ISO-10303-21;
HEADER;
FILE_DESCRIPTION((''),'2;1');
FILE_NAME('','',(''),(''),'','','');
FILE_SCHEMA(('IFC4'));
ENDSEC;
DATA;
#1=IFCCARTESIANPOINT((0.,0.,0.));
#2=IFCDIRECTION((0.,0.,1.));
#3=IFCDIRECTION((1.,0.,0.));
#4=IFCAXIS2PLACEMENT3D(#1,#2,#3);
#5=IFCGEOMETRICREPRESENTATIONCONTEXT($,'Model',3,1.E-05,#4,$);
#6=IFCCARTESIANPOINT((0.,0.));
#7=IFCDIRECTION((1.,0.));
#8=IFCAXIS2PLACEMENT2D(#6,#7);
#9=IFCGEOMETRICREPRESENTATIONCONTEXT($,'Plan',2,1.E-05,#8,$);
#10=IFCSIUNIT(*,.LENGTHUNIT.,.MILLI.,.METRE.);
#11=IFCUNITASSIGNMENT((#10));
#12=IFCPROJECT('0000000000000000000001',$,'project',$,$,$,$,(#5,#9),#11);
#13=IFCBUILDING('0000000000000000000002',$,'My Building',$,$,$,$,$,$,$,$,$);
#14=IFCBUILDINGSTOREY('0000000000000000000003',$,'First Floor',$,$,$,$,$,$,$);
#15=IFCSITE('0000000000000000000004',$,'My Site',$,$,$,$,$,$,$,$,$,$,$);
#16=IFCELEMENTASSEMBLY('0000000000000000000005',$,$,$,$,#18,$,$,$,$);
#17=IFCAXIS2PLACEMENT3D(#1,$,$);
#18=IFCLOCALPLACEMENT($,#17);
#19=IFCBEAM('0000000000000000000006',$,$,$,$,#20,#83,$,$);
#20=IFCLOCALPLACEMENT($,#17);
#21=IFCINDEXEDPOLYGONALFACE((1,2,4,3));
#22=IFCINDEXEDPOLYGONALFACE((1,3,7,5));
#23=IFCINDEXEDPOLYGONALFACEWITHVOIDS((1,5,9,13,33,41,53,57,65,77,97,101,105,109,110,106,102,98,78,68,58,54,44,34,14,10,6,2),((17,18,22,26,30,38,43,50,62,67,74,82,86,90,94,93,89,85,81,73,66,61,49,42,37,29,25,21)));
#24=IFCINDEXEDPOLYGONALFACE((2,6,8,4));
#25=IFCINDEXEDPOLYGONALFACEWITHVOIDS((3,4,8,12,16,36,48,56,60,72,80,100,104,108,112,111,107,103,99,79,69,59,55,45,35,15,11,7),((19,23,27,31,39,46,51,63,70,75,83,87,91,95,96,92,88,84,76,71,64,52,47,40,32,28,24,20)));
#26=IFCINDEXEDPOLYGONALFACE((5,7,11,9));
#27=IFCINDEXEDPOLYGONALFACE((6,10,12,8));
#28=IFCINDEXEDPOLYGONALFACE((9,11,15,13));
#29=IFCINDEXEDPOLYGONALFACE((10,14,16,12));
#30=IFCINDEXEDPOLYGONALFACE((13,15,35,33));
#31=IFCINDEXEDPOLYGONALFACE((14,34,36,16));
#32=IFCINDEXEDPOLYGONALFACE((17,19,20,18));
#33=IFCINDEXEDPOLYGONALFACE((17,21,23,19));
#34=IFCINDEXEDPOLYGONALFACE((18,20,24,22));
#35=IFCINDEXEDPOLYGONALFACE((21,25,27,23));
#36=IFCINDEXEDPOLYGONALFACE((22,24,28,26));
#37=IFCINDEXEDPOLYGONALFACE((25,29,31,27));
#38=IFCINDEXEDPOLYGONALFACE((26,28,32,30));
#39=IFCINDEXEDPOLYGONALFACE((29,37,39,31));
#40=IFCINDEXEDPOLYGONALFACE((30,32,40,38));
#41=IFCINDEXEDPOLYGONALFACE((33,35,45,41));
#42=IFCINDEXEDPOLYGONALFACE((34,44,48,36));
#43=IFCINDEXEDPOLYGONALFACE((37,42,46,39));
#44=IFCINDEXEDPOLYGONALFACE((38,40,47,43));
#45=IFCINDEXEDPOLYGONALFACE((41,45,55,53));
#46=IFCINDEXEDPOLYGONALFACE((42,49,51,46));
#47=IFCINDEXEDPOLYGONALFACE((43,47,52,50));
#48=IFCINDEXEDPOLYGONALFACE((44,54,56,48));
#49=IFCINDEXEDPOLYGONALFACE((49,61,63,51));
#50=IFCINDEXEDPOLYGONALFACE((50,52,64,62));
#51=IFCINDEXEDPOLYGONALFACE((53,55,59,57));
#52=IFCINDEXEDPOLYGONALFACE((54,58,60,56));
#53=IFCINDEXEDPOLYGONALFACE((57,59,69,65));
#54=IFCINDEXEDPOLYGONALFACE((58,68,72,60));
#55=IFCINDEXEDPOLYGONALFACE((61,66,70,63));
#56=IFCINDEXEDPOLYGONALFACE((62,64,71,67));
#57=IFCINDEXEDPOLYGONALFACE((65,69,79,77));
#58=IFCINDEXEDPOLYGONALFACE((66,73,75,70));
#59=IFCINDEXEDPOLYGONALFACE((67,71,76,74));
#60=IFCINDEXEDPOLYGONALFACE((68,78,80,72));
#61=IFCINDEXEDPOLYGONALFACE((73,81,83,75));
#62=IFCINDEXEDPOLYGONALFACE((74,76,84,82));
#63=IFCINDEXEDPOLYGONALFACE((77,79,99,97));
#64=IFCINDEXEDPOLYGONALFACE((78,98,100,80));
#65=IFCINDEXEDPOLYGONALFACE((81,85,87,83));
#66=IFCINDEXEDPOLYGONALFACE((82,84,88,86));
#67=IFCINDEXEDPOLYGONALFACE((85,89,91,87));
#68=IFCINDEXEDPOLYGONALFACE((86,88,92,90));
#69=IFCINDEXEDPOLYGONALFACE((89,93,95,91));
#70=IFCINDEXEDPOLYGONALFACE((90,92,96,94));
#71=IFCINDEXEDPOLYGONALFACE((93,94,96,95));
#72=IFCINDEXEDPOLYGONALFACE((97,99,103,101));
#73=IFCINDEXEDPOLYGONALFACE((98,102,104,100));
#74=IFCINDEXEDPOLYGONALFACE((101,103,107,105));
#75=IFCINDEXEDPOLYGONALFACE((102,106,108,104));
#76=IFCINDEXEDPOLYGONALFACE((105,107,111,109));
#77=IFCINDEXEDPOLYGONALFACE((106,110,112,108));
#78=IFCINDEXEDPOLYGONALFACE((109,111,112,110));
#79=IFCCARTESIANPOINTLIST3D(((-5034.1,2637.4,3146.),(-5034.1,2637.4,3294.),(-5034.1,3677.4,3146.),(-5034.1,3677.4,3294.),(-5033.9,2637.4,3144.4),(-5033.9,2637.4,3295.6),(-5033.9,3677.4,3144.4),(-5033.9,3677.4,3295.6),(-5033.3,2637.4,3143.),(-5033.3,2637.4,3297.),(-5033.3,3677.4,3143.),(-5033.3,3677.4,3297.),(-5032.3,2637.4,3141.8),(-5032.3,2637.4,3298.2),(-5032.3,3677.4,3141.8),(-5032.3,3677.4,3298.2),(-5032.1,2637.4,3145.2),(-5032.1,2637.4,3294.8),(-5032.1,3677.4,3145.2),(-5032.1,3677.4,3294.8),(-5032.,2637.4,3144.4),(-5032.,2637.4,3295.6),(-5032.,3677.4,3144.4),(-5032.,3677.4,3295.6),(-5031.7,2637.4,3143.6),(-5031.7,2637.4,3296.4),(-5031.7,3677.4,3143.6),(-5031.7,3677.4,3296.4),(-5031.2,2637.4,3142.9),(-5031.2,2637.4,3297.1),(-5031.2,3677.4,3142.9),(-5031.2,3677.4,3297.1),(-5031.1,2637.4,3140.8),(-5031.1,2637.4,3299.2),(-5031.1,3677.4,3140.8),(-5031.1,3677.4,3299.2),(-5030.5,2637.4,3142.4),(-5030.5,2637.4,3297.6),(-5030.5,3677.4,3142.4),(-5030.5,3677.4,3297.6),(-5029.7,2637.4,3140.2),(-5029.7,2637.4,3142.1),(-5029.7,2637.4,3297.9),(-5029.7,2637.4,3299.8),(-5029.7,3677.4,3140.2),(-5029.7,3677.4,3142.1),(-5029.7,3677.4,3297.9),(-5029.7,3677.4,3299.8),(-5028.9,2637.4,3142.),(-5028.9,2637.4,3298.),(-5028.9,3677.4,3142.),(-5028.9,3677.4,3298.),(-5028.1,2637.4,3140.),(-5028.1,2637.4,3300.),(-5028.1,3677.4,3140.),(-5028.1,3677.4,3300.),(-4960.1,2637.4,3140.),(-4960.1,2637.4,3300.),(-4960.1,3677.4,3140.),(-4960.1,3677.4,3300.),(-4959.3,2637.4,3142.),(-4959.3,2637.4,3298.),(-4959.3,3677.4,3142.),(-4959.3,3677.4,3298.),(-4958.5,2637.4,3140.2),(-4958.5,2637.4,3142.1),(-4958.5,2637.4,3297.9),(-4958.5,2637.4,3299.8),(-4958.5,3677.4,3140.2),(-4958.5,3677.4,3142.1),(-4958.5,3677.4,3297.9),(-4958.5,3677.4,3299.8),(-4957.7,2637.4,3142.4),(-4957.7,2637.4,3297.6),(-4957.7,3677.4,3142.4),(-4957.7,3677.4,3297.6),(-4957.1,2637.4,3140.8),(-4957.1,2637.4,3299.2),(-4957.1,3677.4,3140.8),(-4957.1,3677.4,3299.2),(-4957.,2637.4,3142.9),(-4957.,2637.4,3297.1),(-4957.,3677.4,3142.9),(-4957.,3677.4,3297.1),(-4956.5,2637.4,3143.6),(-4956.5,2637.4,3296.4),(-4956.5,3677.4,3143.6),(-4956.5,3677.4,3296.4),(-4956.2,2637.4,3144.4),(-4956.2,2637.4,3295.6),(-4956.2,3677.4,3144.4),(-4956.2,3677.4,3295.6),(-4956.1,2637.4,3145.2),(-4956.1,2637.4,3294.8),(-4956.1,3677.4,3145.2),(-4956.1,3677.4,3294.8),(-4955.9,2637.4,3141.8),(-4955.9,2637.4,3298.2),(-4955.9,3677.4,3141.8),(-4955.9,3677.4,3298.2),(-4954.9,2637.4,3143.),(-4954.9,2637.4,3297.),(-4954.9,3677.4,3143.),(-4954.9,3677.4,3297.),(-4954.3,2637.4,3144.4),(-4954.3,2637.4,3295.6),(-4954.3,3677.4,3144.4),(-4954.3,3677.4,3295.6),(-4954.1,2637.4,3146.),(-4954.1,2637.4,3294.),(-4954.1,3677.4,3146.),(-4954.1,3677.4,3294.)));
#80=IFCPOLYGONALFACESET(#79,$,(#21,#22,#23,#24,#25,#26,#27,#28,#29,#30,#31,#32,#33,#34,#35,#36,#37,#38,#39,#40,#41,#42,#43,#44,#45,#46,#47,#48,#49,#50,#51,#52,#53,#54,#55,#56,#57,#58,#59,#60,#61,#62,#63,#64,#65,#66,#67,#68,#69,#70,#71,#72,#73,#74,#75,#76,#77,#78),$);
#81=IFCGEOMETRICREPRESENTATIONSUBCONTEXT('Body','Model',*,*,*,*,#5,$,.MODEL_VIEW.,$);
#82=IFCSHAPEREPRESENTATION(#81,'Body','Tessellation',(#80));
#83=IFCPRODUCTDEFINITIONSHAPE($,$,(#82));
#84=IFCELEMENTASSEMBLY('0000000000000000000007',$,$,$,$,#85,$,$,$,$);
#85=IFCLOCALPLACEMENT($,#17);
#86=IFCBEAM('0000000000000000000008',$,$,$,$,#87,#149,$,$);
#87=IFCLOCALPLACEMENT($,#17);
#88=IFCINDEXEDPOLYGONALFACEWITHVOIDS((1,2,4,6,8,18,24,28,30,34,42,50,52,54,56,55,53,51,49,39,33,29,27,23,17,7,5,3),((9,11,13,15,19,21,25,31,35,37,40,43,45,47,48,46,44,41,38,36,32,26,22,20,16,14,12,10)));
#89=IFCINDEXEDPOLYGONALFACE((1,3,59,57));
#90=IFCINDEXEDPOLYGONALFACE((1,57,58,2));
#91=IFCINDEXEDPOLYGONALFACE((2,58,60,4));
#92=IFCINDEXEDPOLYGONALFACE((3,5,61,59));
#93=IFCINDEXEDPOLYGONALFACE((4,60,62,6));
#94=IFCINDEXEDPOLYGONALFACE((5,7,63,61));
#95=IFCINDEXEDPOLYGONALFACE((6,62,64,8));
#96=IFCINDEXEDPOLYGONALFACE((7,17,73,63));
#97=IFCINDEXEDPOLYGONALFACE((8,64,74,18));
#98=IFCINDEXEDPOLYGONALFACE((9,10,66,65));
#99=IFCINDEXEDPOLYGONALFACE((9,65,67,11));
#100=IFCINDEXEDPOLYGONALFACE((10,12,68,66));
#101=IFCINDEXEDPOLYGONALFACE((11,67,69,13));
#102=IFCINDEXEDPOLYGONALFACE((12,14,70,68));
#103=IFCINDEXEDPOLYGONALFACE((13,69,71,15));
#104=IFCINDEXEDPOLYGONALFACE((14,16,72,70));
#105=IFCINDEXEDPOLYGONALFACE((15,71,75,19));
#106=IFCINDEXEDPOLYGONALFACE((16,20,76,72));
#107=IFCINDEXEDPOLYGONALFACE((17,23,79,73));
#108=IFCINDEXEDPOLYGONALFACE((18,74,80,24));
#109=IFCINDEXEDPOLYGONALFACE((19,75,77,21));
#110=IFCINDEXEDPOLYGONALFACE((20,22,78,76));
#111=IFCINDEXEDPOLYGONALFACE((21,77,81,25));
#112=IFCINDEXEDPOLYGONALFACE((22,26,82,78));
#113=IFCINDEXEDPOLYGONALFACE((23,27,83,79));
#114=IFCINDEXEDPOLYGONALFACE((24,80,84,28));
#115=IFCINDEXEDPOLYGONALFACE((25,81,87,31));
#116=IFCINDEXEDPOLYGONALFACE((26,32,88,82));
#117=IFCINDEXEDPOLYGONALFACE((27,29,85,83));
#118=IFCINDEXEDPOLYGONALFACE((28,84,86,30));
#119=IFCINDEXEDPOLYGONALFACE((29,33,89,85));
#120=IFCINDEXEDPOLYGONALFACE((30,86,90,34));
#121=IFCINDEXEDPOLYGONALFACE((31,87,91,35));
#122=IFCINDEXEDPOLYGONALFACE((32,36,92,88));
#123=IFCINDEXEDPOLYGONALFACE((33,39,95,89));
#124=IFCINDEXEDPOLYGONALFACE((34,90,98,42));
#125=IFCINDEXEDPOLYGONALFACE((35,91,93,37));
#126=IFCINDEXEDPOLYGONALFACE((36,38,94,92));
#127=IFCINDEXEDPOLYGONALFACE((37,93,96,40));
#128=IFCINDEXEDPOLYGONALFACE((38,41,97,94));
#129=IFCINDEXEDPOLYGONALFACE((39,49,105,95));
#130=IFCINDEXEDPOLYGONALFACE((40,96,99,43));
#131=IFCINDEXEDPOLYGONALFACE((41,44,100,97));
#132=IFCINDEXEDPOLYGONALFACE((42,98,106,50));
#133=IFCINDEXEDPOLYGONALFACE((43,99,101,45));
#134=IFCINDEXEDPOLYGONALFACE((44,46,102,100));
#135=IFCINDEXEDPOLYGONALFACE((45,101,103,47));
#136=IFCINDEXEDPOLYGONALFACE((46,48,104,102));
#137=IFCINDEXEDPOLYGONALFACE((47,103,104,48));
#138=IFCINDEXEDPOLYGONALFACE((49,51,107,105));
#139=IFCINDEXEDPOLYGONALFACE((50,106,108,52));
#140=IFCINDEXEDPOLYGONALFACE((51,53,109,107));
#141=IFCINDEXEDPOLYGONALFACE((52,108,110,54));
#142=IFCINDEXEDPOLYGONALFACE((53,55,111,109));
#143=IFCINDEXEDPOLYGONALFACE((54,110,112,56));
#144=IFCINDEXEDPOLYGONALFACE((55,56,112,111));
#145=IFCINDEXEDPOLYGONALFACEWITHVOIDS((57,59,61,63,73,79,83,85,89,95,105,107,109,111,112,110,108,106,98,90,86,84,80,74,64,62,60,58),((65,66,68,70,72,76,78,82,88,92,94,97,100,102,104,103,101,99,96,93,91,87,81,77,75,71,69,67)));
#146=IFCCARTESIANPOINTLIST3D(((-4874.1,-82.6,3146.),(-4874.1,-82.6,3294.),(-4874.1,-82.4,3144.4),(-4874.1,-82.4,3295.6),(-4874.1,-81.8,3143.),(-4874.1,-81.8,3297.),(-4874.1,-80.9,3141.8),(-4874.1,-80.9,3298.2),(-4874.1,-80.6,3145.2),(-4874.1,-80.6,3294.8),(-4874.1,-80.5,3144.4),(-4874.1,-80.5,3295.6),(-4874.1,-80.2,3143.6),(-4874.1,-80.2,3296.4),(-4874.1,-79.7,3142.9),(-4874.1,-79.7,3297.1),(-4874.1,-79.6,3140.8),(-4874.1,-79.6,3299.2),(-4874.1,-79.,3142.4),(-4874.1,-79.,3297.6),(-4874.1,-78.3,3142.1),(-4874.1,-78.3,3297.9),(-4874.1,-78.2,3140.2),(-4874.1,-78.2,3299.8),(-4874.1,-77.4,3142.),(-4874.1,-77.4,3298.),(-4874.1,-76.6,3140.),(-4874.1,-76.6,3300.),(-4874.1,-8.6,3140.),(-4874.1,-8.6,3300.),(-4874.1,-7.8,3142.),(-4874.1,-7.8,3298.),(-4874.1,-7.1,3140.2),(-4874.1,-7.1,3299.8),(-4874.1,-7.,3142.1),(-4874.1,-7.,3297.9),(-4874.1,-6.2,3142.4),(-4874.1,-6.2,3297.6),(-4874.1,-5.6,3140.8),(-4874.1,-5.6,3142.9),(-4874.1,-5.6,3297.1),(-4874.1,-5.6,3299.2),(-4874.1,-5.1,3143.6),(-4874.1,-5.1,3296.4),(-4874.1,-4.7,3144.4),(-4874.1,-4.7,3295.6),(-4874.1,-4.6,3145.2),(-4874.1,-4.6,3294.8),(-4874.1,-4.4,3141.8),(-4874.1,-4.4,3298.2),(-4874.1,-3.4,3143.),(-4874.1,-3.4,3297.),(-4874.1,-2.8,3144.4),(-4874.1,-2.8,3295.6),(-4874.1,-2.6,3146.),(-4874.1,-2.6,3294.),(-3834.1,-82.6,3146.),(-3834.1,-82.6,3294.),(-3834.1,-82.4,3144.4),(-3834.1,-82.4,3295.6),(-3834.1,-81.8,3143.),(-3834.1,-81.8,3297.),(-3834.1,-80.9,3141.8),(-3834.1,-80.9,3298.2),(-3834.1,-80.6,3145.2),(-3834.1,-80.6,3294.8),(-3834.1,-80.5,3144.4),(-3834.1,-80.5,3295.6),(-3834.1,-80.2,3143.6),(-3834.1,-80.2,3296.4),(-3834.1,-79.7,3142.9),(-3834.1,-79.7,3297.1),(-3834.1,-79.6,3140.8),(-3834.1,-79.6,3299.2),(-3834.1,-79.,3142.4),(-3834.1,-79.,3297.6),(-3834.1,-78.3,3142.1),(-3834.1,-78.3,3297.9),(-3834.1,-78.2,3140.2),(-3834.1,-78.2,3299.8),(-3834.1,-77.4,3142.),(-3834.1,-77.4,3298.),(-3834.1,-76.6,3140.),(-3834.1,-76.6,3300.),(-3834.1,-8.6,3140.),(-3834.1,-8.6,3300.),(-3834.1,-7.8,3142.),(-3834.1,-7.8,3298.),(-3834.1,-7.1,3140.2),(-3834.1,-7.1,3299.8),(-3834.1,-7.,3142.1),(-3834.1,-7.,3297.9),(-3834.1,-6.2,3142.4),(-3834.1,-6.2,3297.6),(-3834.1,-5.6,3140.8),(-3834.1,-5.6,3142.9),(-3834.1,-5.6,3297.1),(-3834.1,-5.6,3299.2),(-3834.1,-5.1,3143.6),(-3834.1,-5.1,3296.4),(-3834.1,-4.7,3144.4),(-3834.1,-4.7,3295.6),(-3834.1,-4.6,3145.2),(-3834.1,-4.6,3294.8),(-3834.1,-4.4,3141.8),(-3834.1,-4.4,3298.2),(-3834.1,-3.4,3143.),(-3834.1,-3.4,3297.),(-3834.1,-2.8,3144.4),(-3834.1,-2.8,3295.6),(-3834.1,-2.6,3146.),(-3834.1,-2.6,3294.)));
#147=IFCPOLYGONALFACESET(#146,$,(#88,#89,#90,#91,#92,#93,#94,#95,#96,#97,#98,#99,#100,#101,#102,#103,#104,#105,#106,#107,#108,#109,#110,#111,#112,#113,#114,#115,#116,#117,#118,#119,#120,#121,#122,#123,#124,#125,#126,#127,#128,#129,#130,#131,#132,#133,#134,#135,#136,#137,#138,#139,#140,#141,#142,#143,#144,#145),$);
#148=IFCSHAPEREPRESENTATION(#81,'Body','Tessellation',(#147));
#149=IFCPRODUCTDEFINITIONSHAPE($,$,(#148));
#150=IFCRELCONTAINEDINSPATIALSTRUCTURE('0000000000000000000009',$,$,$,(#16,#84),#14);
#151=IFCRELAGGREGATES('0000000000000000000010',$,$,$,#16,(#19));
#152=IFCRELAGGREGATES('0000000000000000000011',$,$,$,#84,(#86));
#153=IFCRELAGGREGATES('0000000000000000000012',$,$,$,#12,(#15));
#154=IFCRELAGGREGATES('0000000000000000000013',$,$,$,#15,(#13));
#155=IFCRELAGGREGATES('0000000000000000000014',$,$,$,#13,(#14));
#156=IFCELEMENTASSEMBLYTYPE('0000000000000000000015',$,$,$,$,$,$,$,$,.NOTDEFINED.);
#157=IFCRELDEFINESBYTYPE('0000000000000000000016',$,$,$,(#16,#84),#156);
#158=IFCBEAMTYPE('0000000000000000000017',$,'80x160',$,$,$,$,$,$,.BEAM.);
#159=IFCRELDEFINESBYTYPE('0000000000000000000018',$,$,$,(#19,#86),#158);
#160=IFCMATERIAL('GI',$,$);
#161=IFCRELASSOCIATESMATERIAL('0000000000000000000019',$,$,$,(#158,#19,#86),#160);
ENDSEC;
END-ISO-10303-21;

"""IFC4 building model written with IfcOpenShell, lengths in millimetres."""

from ifc_helpers import new_model, si_unit, frame, origin_with_axes, origin_2d_with_axis, place, context, subcontext, project, spatial, hollow_rectangle, extrude, material, material_profile, profile_set, profile_usage, type_object, element, aggregate, save


model = new_model("IFC4")

# Units and contexts
model_context = context("Model", 3, precision=1e-05, world=origin_with_axes())
plan_context = context("Plan", 2, precision=1e-05, world=origin_2d_with_axis())
body_context = subcontext(model_context, "Body", "Model", "MODEL_VIEW")
ifc_project = project(units=[si_unit("LENGTHUNIT", "METRE", prefix="MILLI")], contexts=[model_context, plan_context])

# Site, building, storey
site = spatial("IfcSite", under=ifc_project, Name="My Site")
building = spatial("IfcBuilding", under=site, Name="My Building")
storey = spatial("IfcBuildingStorey", under=building, Name="First Floor")

# Element assemblies, beams
element_assembly_type = type_object("IfcElementAssemblyType", PredefinedType="NOTDEFINED")
ifc_material = material(Name="GI")
ifc_material_profile = material_profile(ifc_material, hollow_rectangle(XDim=80.0, YDim=160.0, WallThickness=2.0, InnerFilletRadius=3.2, OuterFilletRadius=6.0))
ifc_profile_set = profile_set([ifc_material_profile], Name="80x160 GI Rectangular Hollow")
beam_type = type_object("IfcBeamType", Name="80x160", PredefinedType="BEAM", material=ifc_profile_set)
assembly_1_placement = place(None, frame((-4994.1, 2557.4, 3220.0), z_axis=(0.0, 1.0, 0.0), x_axis=(1.0, 0.0, 0.0)))
assembly_1 = element("IfcElementAssembly", 1, at=assembly_1_placement, inside=storey, type_object=element_assembly_type)
ifc_profile_usage_1 = profile_usage(ifc_profile_set)
beam_1_placement = place(assembly_1_placement, frame((0.0, 0.0, 80.0), z_axis=(0.0, 0.0, 1.0), x_axis=(1.0, 0.0, 0.0)))
beam_1 = element("IfcBeam", 2, at=beam_1_placement, type_object=beam_type, material=ifc_profile_usage_1, context=body_context, shape_type="SweptSolid", body=[
    extrude(hollow_rectangle(XDim=80.0, YDim=160.0, WallThickness=2.0, InnerFilletRadius=3.2, OuterFilletRadius=6.0), origin_with_axes(), (0.0, 0.0, 1.0), 1040.0),
])
aggregate(assembly_1, [beam_1])
assembly_2_placement = place(None, frame((-4954.1, -42.6, 3220.0), z_axis=(1.0, 0.0, 0.0), x_axis=(0.0, 1.0, 0.0)))
assembly_2 = element("IfcElementAssembly", 3, at=assembly_2_placement, inside=storey, type_object=element_assembly_type)
ifc_profile_usage_2 = profile_usage(ifc_profile_set)
beam_2_placement = place(assembly_2_placement, frame((0.0, 0.0, 80.0), z_axis=(0.0, 0.0, 1.0), x_axis=(1.0, 0.0, 0.0)))
beam_2 = element("IfcBeam", 4, at=beam_2_placement, type_object=beam_type, material=ifc_profile_usage_2, context=body_context, shape_type="SweptSolid", body=[
    extrude(hollow_rectangle(XDim=80.0, YDim=160.0, WallThickness=2.0, InnerFilletRadius=3.2, OuterFilletRadius=6.0), origin_with_axes(), (0.0, 0.0, 1.0), 1040.0),
])
aggregate(assembly_2, [beam_2])

save(model, "model.ifc")
